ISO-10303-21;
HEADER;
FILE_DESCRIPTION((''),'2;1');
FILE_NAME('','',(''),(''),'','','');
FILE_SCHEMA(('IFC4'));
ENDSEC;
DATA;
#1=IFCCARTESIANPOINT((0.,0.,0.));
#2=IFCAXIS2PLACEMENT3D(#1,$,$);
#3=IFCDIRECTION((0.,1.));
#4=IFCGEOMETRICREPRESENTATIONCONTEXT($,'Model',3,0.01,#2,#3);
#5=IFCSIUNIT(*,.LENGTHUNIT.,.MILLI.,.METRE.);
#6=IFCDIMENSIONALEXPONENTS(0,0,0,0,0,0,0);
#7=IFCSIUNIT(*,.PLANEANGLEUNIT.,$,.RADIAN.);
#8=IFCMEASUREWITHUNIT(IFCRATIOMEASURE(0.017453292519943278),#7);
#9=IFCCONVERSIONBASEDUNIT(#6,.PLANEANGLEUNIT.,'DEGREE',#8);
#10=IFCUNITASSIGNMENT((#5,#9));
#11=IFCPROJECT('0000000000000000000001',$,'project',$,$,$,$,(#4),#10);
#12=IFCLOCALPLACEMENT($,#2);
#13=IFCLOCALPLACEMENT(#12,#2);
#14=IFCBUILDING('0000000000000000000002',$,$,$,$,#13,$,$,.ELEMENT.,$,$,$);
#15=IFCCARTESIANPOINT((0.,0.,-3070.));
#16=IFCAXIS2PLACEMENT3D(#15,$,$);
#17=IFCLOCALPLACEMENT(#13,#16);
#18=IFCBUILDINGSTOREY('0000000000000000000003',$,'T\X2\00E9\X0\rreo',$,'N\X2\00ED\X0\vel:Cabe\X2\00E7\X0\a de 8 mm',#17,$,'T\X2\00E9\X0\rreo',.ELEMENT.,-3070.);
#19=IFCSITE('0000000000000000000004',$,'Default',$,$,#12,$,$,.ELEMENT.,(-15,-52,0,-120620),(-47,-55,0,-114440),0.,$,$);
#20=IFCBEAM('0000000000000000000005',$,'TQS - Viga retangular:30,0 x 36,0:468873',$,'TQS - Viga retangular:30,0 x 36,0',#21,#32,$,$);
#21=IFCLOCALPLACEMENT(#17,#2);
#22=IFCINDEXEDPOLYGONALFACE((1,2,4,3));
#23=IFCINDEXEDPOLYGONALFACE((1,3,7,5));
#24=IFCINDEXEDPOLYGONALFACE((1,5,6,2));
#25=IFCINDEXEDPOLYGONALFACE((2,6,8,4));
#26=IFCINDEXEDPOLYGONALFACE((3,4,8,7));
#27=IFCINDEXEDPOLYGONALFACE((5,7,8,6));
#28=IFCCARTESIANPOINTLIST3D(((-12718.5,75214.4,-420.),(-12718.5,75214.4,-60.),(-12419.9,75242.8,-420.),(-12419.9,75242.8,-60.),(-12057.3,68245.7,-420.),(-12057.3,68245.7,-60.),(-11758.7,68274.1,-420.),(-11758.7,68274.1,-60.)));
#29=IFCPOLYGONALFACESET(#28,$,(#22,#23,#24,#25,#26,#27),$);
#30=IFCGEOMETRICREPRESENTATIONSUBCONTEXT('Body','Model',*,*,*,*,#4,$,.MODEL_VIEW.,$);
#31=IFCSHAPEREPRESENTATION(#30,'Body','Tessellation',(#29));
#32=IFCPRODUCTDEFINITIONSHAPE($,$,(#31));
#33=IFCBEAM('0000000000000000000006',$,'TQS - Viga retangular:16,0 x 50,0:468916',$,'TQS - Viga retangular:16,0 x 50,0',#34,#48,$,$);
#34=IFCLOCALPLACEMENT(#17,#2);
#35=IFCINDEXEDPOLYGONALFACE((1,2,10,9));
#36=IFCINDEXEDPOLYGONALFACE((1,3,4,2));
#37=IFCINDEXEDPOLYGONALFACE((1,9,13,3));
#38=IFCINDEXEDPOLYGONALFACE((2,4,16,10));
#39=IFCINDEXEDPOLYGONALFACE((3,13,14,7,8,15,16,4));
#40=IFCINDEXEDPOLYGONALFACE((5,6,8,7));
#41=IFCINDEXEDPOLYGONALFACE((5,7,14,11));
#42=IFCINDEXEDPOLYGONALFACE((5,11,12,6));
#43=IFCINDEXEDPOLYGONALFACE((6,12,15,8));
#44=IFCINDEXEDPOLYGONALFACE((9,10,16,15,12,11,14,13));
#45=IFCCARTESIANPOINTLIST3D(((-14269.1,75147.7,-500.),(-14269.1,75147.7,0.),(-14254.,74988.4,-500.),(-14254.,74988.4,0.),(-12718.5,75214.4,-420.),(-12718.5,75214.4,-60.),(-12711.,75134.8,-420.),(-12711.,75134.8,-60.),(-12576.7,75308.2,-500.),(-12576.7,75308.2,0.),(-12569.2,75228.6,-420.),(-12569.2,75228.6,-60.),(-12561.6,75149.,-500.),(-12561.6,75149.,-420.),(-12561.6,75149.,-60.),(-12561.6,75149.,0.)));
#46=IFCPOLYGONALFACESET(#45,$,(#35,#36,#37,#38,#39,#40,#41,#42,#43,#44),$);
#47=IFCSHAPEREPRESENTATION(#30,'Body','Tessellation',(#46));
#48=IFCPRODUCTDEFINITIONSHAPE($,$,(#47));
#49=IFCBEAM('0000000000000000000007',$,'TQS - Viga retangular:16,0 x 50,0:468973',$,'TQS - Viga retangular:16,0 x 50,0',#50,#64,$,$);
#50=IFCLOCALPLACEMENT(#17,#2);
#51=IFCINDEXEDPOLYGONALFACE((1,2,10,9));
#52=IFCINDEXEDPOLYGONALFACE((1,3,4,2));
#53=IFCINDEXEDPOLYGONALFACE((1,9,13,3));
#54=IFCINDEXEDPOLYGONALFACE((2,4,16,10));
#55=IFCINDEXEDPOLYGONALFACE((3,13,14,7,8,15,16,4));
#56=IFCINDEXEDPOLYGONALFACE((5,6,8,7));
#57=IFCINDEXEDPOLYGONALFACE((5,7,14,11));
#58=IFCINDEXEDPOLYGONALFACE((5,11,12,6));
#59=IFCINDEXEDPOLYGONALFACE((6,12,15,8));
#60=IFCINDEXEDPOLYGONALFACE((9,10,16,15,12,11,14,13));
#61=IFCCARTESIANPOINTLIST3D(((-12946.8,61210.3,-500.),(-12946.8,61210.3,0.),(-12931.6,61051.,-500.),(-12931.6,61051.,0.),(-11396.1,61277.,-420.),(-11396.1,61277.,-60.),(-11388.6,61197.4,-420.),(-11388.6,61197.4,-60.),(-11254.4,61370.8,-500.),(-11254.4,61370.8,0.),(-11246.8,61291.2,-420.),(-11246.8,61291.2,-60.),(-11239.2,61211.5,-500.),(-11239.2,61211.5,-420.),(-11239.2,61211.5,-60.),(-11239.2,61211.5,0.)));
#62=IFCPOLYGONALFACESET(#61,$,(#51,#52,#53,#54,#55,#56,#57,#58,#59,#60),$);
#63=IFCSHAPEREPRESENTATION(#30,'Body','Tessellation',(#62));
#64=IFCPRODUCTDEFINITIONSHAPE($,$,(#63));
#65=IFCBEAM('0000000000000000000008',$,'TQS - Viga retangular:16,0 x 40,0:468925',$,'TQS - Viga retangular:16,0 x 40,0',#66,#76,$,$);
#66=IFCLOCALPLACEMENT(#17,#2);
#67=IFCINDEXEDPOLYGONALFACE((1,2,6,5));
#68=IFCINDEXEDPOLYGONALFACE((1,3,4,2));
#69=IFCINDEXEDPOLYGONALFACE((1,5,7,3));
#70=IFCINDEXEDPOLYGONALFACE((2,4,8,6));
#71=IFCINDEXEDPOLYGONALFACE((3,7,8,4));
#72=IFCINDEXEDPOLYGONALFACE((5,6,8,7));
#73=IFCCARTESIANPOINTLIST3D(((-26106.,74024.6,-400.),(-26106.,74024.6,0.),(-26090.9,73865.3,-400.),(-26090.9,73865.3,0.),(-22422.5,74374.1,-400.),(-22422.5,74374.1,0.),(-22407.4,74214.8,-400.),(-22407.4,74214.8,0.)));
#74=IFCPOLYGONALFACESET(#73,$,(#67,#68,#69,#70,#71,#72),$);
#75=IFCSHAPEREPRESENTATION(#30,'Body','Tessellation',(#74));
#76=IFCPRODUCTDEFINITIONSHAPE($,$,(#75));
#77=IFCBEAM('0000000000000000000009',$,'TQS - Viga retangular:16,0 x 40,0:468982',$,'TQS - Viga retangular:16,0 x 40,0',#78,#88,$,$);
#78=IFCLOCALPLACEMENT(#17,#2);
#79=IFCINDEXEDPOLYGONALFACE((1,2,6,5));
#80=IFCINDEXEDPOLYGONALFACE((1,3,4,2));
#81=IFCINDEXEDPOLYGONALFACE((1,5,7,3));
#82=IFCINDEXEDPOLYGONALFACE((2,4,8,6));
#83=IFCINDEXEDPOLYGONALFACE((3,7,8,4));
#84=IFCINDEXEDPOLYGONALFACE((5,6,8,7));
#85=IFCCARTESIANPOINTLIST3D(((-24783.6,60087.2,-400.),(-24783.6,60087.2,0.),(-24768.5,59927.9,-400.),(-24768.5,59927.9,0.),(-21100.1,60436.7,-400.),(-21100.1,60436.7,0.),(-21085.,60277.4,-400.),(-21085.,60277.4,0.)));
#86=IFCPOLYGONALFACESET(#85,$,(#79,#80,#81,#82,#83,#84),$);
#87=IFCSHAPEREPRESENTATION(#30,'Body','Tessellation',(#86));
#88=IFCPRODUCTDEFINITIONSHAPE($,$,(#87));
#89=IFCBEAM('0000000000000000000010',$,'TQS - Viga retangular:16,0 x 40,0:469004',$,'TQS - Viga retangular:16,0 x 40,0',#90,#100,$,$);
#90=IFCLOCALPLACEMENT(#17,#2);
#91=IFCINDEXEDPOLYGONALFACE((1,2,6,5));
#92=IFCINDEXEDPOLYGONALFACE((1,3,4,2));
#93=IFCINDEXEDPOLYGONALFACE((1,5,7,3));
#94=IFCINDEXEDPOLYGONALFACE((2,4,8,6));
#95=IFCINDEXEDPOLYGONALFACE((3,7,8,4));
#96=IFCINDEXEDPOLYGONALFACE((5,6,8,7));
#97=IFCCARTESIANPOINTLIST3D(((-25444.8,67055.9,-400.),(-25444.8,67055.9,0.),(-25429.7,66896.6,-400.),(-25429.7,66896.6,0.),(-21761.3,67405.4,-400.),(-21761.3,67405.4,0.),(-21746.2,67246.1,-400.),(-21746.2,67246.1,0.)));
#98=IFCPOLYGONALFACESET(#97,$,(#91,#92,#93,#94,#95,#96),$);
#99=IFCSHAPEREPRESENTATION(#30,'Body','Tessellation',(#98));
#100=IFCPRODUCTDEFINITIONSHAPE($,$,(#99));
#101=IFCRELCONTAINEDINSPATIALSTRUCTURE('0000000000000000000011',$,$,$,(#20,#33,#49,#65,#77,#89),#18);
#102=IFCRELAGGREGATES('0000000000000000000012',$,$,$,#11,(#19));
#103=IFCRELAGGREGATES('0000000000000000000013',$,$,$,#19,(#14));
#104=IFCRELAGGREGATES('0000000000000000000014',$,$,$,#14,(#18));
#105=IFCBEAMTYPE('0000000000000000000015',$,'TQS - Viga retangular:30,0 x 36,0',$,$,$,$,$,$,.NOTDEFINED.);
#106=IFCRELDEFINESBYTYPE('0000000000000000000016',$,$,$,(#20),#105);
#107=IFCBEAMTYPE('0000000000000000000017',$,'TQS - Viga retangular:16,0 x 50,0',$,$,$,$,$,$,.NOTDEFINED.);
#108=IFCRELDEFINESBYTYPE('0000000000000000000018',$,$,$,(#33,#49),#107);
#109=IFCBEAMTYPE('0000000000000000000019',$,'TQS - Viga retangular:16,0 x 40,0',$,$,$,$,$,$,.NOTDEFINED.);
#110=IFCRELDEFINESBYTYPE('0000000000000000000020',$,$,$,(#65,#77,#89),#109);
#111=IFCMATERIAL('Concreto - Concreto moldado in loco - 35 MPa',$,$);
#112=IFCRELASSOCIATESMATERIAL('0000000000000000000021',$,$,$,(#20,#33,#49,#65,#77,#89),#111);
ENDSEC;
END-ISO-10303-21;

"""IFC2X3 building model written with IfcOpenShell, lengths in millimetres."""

from ifc_helpers import new_model, entity, si_unit, converted_unit, direction, frame, frame_2d, origin, origin_2d_with_axis, place, context, subcontext, project, spatial, polyline, rectangle, extrude, boolean, clip, bounded_halfspace, material, type_object, element, save


model = new_model("IFC2X3")

# Units and contexts
model_context = context("Model", 3, precision=0.01, world=origin(), true_north=direction((0.0, 1.0)))
body_context = subcontext(model_context, "Body", "Model", "MODEL_VIEW")
ifc_project = project(units=[si_unit("LENGTHUNIT", "METRE", prefix="MILLI"), converted_unit("PLANEANGLEUNIT", "DEGREE", entity("IfcRatioMeasure", 0.017453292519943278), si_unit("PLANEANGLEUNIT", "RADIAN"), dimensions=[0, 0, 0, 0, 0, 0, 0])], contexts=[model_context])

# Site, building, storey
site_placement = place(None, origin())
site = spatial("IfcSite", under=ifc_project, at=site_placement, Name="Default", CompositionType="ELEMENT", RefLatitude=(-15, -52, 0, -120620), RefLongitude=(-47, -55, 0, -114440), RefElevation=0.0)
building_placement = place(site_placement, origin())
building = spatial("IfcBuilding", under=site, at=building_placement, CompositionType="ELEMENT")
storey_placement = place(building_placement, frame((0.0, 0.0, -3070.0)))
storey = spatial("IfcBuildingStorey", under=building, at=storey_placement, Name="Térreo", ObjectType="Nível:Cabeça de 8 mm", LongName="Térreo", CompositionType="ELEMENT", Elevation=-3070.0)

# Beams
ifc_material_1 = material(Name="Concreto - Concreto moldado in loco - 35 MPa")
beam_type_1 = type_object("IfcBeamType", Name="TQS - Viga retangular:30,0 x 36,0", PredefinedType="NOTDEFINED")
beam_1_placement = place(storey_placement, frame((-11908.0, 68259.9, -60.0), z_axis=(0.0, 0.0, 1.0), x_axis=(-0.094456, 0.995529, 0.0)))
element("IfcBeam", 1, at=beam_1_placement, inside=storey, type_object=beam_type_1, material=ifc_material_1, Name="TQS - Viga retangular:30,0 x 36,0:468873", ObjectType="TQS - Viga retangular:30,0 x 36,0", context=body_context, shape_type="SweptSolid", body=[
    extrude(rectangle(XDim=360.0, YDim=300.0, at=frame_2d((0.0, 0.0), x_axis=(1.0, 0.0))), frame((0.0, 0.0, -180.0), z_axis=(1.0, 0.0, 0.0), x_axis=(0.0, 0.0, -1.0)), (0.0, 0.0, 1.0), 7000.0),
])
beam_type_2 = type_object("IfcBeamType", Name="TQS - Viga retangular:16,0 x 50,0", PredefinedType="NOTDEFINED")
beam_2_placement = place(storey_placement, frame((-12569.2, 75228.6, 0.0), z_axis=(0.0, 0.0, 1.0), x_axis=(-0.995529, -0.094456, 0.0)))
element("IfcBeam", 2, at=beam_2_placement, inside=storey, type_object=beam_type_2, material=ifc_material_1, Name="TQS - Viga retangular:16,0 x 50,0:468916", ObjectType="TQS - Viga retangular:16,0 x 50,0", context=body_context, shape_type="SweptSolid", body=[
    boolean("DIFFERENCE", clip(extrude(rectangle(XDim=500.0, YDim=160.0, at=origin_2d_with_axis()), frame((0.0, 0.0, -250.0), z_axis=(1.0, 0.0, 0.0), x_axis=(0.0, 0.0, -1.0)), (0.0, 0.0, 1.0), 1700.0), bounded_halfspace(frame((150.0, 0.0, -420.0), z_axis=(-1.0, 0.0, 0.0), x_axis=(0.0, 1.0, 0.0)), False, frame((0.0, 0.0, -250.0), z_axis=(1.0, 0.0, 0.0), x_axis=(0.0, 0.0, -1.0)), polyline([(170.0, 0.0), (-190.0, 0.0), (-190.0, 80.0), (-90.0, 80.0), (170.0, 80.0), (170.0, 0.0)]))), extrude(rectangle(XDim=360.0, YDim=80.0, at=frame_2d((0.0, 0.0), x_axis=(0.0, 1.0))), frame((0.0, 40.0, -240.0), z_axis=(-1.0, 0.0, 0.0), x_axis=(0.0, -1.0, 0.0)), (0.0, 0.0, -1.0), 150.0)),
])
beam_3_placement = place(storey_placement, frame((-11246.8, 61291.2, 0.0), z_axis=(0.0, 0.0, 1.0), x_axis=(-0.995529, -0.094456, 0.0)))
element("IfcBeam", 3, at=beam_3_placement, inside=storey, type_object=beam_type_2, material=ifc_material_1, Name="TQS - Viga retangular:16,0 x 50,0:468973", ObjectType="TQS - Viga retangular:16,0 x 50,0", context=body_context, shape_type="SweptSolid", body=[
    boolean("DIFFERENCE", clip(extrude(rectangle(XDim=500.0, YDim=160.0, at=frame_2d((0.0, 0.0), x_axis=(1.0, 0.0))), frame((0.0, 0.0, -250.0), z_axis=(1.0, 0.0, 0.0), x_axis=(0.0, 0.0, -1.0)), (0.0, 0.0, 1.0), 1700.0), bounded_halfspace(frame((150.0, 0.0, -420.0), z_axis=(-1.0, 0.0, 0.0), x_axis=(0.0, 1.0, 0.0)), False, frame((0.0, 0.0, -250.0), z_axis=(1.0, 0.0, 0.0), x_axis=(0.0, 0.0, -1.0)), polyline([(170.0, 0.0), (-190.0, 0.0), (-190.0, 80.0), (-90.0, 80.0), (170.0, 80.0), (170.0, 0.0)]))), extrude(rectangle(XDim=360.0, YDim=80.0, at=frame_2d((0.0, 0.0), x_axis=(0.0, 1.0))), frame((0.0, 40.0, -240.0), z_axis=(-1.0, 0.0, 0.0), x_axis=(0.0, -1.0, 0.0)), (0.0, 0.0, -1.0), 150.0)),
])
beam_type_3 = type_object("IfcBeamType", Name="TQS - Viga retangular:16,0 x 40,0", PredefinedType="NOTDEFINED")
beam_4_placement = place(storey_placement, frame((-22320.4, 74303.4, 0.0), z_axis=(0.0, 0.0, 1.0), x_axis=(-0.995529, -0.094456, 0.0)))
element("IfcBeam", 4, at=beam_4_placement, inside=storey, type_object=beam_type_3, material=ifc_material_1, Name="TQS - Viga retangular:16,0 x 40,0:468925", ObjectType="TQS - Viga retangular:16,0 x 40,0", context=body_context, shape_type="SweptSolid", body=[
    extrude(rectangle(XDim=400.0, YDim=160.0, at=frame_2d((0.0, 0.0), x_axis=(1.0, 0.0))), frame((95.0, 0.0, -200.0), z_axis=(1.0, 0.0, 0.0), x_axis=(0.0, 0.0, -1.0)), (0.0, 0.0, 1.0), 3700.0),
])
beam_5_placement = place(storey_placement, frame((-20998.0, 60366.0, 0.0), z_axis=(0.0, 0.0, 1.0), x_axis=(-0.995529, -0.094456, 0.0)))
element("IfcBeam", 5, at=beam_5_placement, inside=storey, type_object=beam_type_3, material=ifc_material_1, Name="TQS - Viga retangular:16,0 x 40,0:468982", ObjectType="TQS - Viga retangular:16,0 x 40,0", context=body_context, shape_type="SweptSolid", body=[
    extrude(rectangle(XDim=400.0, YDim=160.0, at=frame_2d((0.0, 0.0), x_axis=(1.0, 0.0))), frame((95.0, 0.0, -200.0), z_axis=(1.0, 0.0, 0.0), x_axis=(0.0, 0.0, -1.0)), (0.0, 0.0, 1.0), 3700.0),
])
beam_6_placement = place(storey_placement, frame((-21659.2, 67334.7, 0.0), z_axis=(0.0, 0.0, 1.0), x_axis=(-0.995529, -0.094456, 0.0)))
element("IfcBeam", 6, at=beam_6_placement, inside=storey, type_object=beam_type_3, material=ifc_material_1, Name="TQS - Viga retangular:16,0 x 40,0:469004", ObjectType="TQS - Viga retangular:16,0 x 40,0", context=body_context, shape_type="SweptSolid", body=[
    extrude(rectangle(XDim=400.0, YDim=160.0, at=frame_2d((0.0, 0.0), x_axis=(1.0, 0.0))), frame((95.0, 0.0, -200.0), z_axis=(1.0, 0.0, 0.0), x_axis=(0.0, 0.0, -1.0)), (0.0, 0.0, 1.0), 3700.0),
])

save(model, "model.ifc")
